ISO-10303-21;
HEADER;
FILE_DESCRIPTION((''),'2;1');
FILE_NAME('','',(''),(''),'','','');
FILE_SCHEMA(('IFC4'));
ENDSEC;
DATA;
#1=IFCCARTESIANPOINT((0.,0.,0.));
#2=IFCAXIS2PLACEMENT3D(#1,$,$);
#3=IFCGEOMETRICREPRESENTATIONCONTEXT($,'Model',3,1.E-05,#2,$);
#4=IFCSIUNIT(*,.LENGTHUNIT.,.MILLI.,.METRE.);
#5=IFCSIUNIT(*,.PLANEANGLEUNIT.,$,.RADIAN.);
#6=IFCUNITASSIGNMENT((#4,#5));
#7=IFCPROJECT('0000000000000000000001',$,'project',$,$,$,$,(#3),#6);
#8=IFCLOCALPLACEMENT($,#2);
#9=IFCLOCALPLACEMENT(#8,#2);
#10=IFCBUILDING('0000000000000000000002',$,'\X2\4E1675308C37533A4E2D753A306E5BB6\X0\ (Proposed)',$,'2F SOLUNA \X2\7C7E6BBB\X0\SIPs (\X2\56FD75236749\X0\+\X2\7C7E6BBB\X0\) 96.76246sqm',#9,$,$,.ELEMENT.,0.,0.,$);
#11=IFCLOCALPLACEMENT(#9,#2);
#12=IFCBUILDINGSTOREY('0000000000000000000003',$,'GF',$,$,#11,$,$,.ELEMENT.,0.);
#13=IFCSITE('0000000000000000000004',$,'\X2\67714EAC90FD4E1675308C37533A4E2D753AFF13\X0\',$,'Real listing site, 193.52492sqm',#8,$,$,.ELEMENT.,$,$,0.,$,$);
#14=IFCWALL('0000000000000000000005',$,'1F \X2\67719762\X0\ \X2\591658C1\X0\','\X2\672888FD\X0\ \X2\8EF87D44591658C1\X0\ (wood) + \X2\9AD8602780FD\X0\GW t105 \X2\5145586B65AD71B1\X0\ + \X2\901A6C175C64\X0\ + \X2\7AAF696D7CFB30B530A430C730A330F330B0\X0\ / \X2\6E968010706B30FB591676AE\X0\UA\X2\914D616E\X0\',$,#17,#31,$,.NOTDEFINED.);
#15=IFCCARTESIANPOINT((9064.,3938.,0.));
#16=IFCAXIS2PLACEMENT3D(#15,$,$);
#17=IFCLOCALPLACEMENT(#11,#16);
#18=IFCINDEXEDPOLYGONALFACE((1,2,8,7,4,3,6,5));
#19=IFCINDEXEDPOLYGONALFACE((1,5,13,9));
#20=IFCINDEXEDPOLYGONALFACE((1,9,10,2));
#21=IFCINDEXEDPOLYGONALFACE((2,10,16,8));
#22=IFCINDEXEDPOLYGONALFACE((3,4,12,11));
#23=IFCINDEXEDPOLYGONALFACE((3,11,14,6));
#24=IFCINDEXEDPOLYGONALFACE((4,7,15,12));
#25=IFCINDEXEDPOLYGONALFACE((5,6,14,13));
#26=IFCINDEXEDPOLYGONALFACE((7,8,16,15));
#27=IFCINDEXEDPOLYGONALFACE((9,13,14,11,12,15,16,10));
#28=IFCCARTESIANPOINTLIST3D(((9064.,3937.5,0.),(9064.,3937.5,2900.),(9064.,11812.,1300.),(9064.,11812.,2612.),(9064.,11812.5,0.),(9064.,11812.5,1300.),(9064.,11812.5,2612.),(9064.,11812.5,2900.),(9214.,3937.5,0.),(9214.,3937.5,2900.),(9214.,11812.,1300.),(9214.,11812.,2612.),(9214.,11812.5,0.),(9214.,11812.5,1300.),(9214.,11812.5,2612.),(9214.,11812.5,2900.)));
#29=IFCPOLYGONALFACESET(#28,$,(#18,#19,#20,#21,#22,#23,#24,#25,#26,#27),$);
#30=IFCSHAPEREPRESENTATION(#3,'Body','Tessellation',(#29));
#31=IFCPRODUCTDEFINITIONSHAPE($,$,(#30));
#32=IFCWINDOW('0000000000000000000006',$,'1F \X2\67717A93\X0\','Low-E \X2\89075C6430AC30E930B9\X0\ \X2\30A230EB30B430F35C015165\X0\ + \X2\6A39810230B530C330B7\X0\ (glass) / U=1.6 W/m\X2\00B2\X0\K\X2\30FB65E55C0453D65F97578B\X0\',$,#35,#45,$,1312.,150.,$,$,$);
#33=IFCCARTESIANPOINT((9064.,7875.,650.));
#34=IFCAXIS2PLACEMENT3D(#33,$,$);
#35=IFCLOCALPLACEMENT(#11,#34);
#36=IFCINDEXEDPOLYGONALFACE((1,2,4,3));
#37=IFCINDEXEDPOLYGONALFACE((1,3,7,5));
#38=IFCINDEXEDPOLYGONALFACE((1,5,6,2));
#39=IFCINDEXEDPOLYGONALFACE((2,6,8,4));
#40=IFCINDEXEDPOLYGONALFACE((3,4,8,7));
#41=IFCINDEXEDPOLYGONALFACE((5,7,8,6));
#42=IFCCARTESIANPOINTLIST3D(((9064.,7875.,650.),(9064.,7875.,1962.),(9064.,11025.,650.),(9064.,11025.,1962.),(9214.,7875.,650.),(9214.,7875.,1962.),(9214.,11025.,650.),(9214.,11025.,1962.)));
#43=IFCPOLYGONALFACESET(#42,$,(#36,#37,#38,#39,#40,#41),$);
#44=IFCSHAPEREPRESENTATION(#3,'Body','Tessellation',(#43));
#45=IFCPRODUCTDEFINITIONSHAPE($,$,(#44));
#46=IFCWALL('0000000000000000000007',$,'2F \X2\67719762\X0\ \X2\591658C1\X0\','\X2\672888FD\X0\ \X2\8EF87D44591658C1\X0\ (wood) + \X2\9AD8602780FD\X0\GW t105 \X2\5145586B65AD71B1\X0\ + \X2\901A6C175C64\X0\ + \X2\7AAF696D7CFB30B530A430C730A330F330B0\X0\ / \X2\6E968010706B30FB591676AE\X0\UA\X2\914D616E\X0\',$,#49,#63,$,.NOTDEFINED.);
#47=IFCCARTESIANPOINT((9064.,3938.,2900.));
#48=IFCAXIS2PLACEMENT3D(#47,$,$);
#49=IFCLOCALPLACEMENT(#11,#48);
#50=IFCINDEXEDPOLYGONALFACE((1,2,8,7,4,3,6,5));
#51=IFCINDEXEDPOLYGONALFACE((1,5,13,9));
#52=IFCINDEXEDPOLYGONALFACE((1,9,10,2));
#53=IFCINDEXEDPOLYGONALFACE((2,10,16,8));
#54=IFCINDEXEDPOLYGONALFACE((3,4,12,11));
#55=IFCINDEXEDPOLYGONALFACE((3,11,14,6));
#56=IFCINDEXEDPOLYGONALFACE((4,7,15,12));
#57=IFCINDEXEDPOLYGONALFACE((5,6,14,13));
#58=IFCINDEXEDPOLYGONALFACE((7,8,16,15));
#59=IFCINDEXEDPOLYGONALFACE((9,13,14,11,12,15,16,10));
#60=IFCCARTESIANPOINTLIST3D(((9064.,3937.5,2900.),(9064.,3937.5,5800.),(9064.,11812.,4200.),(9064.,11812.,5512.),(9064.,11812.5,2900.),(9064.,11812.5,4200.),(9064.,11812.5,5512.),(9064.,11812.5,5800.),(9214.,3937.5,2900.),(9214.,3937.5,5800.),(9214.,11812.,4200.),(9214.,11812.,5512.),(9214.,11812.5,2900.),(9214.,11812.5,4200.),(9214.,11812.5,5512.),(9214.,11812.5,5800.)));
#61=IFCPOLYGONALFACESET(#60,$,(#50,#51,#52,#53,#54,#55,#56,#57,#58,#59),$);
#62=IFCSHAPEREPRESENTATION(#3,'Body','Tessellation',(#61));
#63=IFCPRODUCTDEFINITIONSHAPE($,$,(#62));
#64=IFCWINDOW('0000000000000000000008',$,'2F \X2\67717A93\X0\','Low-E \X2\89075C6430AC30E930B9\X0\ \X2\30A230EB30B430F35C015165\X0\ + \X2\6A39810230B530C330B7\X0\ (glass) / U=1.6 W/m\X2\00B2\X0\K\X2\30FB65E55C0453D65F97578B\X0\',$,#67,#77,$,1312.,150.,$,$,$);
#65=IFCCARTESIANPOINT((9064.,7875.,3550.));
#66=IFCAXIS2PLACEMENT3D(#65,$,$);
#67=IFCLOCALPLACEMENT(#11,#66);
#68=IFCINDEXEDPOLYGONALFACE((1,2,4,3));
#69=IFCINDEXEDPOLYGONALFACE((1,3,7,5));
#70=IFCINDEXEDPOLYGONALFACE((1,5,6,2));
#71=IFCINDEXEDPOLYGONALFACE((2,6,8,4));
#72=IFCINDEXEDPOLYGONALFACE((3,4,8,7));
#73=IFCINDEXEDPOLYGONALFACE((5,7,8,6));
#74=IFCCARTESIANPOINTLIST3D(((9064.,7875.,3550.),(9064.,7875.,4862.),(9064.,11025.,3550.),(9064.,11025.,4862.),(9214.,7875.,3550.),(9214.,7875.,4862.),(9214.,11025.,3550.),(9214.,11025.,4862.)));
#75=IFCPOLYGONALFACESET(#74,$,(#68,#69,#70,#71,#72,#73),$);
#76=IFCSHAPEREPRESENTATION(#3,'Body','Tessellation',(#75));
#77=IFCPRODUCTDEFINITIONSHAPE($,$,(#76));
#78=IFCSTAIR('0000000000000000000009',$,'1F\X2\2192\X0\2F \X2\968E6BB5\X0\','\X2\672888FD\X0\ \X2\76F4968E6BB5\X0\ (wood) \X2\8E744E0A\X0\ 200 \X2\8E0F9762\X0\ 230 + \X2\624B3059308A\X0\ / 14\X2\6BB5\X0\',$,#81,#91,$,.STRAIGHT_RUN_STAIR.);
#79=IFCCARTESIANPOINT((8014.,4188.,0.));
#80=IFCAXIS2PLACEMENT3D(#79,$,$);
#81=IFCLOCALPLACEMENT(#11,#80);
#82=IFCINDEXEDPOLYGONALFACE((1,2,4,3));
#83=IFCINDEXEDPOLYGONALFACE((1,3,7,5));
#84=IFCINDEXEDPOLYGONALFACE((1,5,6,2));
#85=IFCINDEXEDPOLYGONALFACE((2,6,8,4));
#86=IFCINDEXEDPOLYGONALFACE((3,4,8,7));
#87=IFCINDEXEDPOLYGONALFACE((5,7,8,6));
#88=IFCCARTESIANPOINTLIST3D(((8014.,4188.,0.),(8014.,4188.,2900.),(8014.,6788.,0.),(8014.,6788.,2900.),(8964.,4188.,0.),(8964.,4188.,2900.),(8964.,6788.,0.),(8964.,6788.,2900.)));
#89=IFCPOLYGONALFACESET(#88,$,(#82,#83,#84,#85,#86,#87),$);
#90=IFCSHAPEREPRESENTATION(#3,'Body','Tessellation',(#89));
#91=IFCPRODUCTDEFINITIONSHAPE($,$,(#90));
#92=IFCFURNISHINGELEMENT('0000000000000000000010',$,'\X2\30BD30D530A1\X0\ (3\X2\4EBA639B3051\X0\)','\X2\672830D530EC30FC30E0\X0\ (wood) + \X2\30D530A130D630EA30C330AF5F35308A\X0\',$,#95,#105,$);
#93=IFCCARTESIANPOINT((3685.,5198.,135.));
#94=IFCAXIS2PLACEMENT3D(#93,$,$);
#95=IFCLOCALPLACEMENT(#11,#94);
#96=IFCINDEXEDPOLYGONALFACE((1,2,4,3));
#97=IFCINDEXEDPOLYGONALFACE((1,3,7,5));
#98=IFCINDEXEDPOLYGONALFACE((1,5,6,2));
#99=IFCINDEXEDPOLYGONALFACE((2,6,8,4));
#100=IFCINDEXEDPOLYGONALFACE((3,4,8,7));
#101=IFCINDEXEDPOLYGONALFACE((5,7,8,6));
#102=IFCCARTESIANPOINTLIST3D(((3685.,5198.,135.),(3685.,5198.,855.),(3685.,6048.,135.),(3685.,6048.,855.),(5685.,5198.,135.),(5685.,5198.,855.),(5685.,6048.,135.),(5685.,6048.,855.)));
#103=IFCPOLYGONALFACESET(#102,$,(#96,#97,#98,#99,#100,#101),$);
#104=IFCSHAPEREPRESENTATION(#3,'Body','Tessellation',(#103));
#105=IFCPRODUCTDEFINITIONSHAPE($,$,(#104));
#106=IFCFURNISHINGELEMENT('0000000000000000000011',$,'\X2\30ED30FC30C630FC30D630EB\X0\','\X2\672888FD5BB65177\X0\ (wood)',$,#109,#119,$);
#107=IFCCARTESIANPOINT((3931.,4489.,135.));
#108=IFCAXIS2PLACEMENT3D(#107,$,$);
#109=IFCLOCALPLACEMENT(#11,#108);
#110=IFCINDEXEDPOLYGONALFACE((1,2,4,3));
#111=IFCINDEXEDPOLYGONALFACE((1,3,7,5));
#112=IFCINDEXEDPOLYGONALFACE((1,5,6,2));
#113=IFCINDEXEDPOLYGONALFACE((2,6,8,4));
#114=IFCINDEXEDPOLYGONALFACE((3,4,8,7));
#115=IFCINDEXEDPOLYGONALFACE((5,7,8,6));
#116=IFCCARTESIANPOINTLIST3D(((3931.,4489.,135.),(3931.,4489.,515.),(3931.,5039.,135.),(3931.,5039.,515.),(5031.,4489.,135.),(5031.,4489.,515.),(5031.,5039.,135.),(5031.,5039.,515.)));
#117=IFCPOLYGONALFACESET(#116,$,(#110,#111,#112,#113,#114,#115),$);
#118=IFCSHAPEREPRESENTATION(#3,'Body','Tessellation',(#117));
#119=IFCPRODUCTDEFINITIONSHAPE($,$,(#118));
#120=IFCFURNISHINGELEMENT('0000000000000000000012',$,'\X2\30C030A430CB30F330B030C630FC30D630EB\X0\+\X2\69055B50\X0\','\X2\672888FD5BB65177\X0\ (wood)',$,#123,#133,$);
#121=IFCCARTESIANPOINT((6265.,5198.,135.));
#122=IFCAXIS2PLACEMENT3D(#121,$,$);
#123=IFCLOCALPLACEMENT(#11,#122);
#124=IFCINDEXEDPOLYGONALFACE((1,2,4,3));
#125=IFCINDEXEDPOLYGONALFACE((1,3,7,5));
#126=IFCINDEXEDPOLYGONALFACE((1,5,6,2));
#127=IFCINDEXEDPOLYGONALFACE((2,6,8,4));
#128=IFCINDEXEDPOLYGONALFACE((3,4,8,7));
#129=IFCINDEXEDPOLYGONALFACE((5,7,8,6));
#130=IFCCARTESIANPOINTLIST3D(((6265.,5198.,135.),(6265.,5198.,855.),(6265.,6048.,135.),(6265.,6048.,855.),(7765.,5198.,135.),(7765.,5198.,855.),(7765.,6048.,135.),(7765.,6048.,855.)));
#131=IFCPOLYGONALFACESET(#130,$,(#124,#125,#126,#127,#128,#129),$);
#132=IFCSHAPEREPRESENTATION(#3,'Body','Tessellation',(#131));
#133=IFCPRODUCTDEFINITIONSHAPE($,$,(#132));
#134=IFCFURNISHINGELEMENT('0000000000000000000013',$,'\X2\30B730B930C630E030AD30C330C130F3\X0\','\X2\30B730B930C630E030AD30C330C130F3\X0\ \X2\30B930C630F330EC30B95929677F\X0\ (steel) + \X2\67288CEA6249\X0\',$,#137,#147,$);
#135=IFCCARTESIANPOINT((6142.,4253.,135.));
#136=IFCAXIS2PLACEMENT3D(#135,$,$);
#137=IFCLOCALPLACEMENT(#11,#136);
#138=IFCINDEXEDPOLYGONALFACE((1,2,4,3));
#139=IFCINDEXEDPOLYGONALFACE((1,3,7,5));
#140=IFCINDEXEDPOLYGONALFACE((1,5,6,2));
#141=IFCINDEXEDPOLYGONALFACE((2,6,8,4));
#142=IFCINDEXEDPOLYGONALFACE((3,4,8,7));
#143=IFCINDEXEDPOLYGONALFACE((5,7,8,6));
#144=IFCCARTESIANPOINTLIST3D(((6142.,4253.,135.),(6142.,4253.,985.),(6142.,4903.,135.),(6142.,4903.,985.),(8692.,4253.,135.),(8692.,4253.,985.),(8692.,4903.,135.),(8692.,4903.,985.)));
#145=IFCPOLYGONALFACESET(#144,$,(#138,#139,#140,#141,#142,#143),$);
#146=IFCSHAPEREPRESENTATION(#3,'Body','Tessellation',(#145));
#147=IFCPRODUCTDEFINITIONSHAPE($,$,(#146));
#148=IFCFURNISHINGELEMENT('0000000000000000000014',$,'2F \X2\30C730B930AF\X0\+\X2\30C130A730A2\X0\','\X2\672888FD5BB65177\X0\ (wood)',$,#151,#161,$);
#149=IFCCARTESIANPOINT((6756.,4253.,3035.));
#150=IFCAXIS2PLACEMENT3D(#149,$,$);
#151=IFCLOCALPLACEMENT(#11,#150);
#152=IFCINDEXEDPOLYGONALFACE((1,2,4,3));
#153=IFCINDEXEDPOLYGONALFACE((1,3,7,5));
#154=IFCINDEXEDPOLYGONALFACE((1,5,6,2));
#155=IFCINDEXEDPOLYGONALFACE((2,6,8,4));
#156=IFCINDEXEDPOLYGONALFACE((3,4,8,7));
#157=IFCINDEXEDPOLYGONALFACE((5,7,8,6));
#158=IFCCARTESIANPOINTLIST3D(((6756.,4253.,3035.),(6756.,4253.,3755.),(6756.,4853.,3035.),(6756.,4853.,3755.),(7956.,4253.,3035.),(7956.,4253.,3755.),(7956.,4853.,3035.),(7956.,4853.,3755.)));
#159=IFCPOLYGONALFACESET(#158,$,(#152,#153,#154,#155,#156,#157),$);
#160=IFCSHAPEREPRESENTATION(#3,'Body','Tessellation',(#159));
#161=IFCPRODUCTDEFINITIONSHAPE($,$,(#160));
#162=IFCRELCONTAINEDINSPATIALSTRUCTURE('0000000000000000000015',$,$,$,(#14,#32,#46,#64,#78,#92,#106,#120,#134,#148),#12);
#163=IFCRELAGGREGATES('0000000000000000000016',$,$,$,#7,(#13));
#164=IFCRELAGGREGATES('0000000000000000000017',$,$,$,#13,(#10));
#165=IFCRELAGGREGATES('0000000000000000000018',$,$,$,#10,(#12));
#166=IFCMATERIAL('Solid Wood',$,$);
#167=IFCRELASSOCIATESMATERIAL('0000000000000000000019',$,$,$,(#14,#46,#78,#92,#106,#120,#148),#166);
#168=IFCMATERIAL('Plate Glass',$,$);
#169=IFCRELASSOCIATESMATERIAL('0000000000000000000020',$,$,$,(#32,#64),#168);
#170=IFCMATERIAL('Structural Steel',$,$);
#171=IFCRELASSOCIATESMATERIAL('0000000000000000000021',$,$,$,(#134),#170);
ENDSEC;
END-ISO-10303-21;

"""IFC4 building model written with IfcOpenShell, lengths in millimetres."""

from ifc_helpers import new_model, si_unit, frame, frame_2d, origin, place, context, project, spatial, rectangle, extrude, material, element, fill, save


model = new_model("IFC4")

# Units and contexts
model_context = context("Model", 3, precision=1e-05, world=origin())
ifc_project = project(units=[si_unit("LENGTHUNIT", "METRE", prefix="MILLI"), si_unit("PLANEANGLEUNIT", "RADIAN")], contexts=[model_context])

# Site, building, storey
site_placement = place(None, origin())
site = spatial("IfcSite", under=ifc_project, at=site_placement, Name="東京都世田谷区中町３", ObjectType="Real listing site, 193.52492sqm", CompositionType="ELEMENT", RefElevation=0.0)
building_placement = place(site_placement, origin())
building = spatial("IfcBuilding", under=site, at=building_placement, Name="世田谷区中町の家 (Proposed)", ObjectType="2F SOLUNA 籾殻SIPs (国産杉+籾殻) 96.76246sqm", CompositionType="ELEMENT", ElevationOfRefHeight=0.0, ElevationOfTerrain=0.0)
storey_placement = place(building_placement, origin())
storey = spatial("IfcBuildingStorey", under=building, at=storey_placement, Name="GF", CompositionType="ELEMENT", Elevation=0.0)

# Wall, opening, window
ifc_material_1 = material(Name="Solid Wood")
wall_1_placement = place(storey_placement, frame((9064.0, 3938.0, 0.0)))
wall_1 = element("IfcWall", 1, at=wall_1_placement, inside=storey, material=ifc_material_1, Name="1F 東面 外壁", Description="木製 軸組外壁 (wood) + 高性能GW t105 充填断熱 + 通気層 + 窯業系サイディング / 準耐火・外皮UA配慮", PredefinedType="NOTDEFINED", context=model_context, shape_type="SweptSolid", body=[
    extrude(rectangle(XDim=150.0, YDim=7875.0, at=frame_2d((75.0, 3937.0))), frame((9064.0, 3938.0, 0.0)), (0.0, 0.0, 1.0), 2900.0),
])
opening_1_placement = place(storey_placement, frame((9064.0, 7875.0, 650.0)))
opening_1 = element("IfcOpeningElement", 2, at=opening_1_placement, cuts=wall_1, PredefinedType="NOTDEFINED", context=model_context, shape_type="SweptSolid", body=[
    extrude(rectangle(XDim=150.0, YDim=3150.0, at=frame_2d((75.0, 1575.0))), frame((9064.0, 7875.0, 650.0)), (0.0, 0.0, 1.0), 1312.0),
])
ifc_material_2 = material(Name="Plate Glass")
window_1_placement = place(storey_placement, frame((9064.0, 7875.0, 650.0)))
window_1 = element("IfcWindow", 3, at=window_1_placement, inside=storey, material=ifc_material_2, Name="1F 東窓", Description="Low-E 複層ガラス アルゴン封入 + 樹脂サッシ (glass) / U=1.6 W/m²K・日射取得型", OverallHeight=1312.0, OverallWidth=150.0, context=model_context, shape_type="SweptSolid", body=[
    extrude(rectangle(XDim=150.0, YDim=3150.0, at=frame_2d((75.0, 1575.0))), frame((9064.0, 7875.0, 650.0)), (0.0, 0.0, 1.0), 1312.0),
])
fill(opening_1, window_1)

# Wall, opening, window
wall_2_placement = place(storey_placement, frame((9064.0, 3938.0, 2900.0)))
wall_2 = element("IfcWall", 4, at=wall_2_placement, inside=storey, material=ifc_material_1, Name="2F 東面 外壁", Description="木製 軸組外壁 (wood) + 高性能GW t105 充填断熱 + 通気層 + 窯業系サイディング / 準耐火・外皮UA配慮", PredefinedType="NOTDEFINED", context=model_context, shape_type="SweptSolid", body=[
    extrude(rectangle(XDim=150.0, YDim=7875.0, at=frame_2d((75.0, 3937.0))), frame((9064.0, 3938.0, 2900.0)), (0.0, 0.0, 1.0), 2900.0),
])
opening_2_placement = place(storey_placement, frame((9064.0, 7875.0, 3550.0)))
opening_2 = element("IfcOpeningElement", 5, at=opening_2_placement, cuts=wall_2, PredefinedType="NOTDEFINED", context=model_context, shape_type="SweptSolid", body=[
    extrude(rectangle(XDim=150.0, YDim=3150.0, at=frame_2d((75.0, 1575.0))), frame((9064.0, 7875.0, 3550.0)), (0.0, 0.0, 1.0), 1312.0),
])
window_2_placement = place(storey_placement, frame((9064.0, 7875.0, 3550.0)))
window_2 = element("IfcWindow", 6, at=window_2_placement, inside=storey, material=ifc_material_2, Name="2F 東窓", Description="Low-E 複層ガラス アルゴン封入 + 樹脂サッシ (glass) / U=1.6 W/m²K・日射取得型", OverallHeight=1312.0, OverallWidth=150.0, context=model_context, shape_type="SweptSolid", body=[
    extrude(rectangle(XDim=150.0, YDim=3150.0, at=frame_2d((75.0, 1575.0))), frame((9064.0, 7875.0, 3550.0)), (0.0, 0.0, 1.0), 1312.0),
])
fill(opening_2, window_2)

# Stair
stair_placement = place(storey_placement, frame((8014.0, 4188.0, 0.0)))
element("IfcStair", 7, at=stair_placement, inside=storey, material=ifc_material_1, Name="1F→2F 階段", Description="木製 直階段 (wood) 蹴上 200 踏面 230 + 手すり / 14段", PredefinedType="STRAIGHT_RUN_STAIR", context=model_context, shape_type="SweptSolid", body=[
    extrude(rectangle(XDim=950.0, YDim=2600.0, at=frame_2d((475.0, 1300.0))), frame((8014.0, 4188.0, 0.0)), (0.0, 0.0, 1.0), 2900.0),
])

# Furnishing elements
furnishing_1_placement = place(storey_placement, frame((3685.0, 5198.0, 135.0)))
element("IfcFurnishingElement", 8, at=furnishing_1_placement, inside=storey, material=ifc_material_1, Name="ソファ (3人掛け)", Description="木フレーム (wood) + ファブリック張り", context=model_context, shape_type="SweptSolid", body=[
    extrude(rectangle(XDim=2000.0, YDim=850.0, at=frame_2d((1000.0, 425.0))), frame((3685.0, 5198.0, 135.0)), (0.0, 0.0, 1.0), 720.0),
])
furnishing_2_placement = place(storey_placement, frame((3931.0, 4489.0, 135.0)))
element("IfcFurnishingElement", 9, at=furnishing_2_placement, inside=storey, material=ifc_material_1, Name="ローテーブル", Description="木製家具 (wood)", context=model_context, shape_type="SweptSolid", body=[
    extrude(rectangle(XDim=1100.0, YDim=550.0, at=frame_2d((550.0, 275.0))), frame((3931.0, 4489.0, 135.0)), (0.0, 0.0, 1.0), 380.0),
])
furnishing_3_placement = place(storey_placement, frame((6265.0, 5198.0, 135.0)))
element("IfcFurnishingElement", 10, at=furnishing_3_placement, inside=storey, material=ifc_material_1, Name="ダイニングテーブル+椅子", Description="木製家具 (wood)", context=model_context, shape_type="SweptSolid", body=[
    extrude(rectangle(XDim=1500.0, YDim=850.0, at=frame_2d((750.0, 425.0))), frame((6265.0, 5198.0, 135.0)), (0.0, 0.0, 1.0), 720.0),
])
ifc_material_3 = material(Name="Structural Steel")
furnishing_4_placement = place(storey_placement, frame((6142.0, 4253.0, 135.0)))
element("IfcFurnishingElement", 11, at=furnishing_4_placement, inside=storey, material=ifc_material_3, Name="システムキッチン", Description="システムキッチン ステンレス天板 (steel) + 木質扉", context=model_context, shape_type="SweptSolid", body=[
    extrude(rectangle(XDim=2550.0, YDim=650.0, at=frame_2d((1275.0, 325.0))), frame((6142.0, 4253.0, 135.0)), (0.0, 0.0, 1.0), 850.0),
])
furnishing_5_placement = place(storey_placement, frame((6756.0, 4253.0, 3035.0)))
element("IfcFurnishingElement", 12, at=furnishing_5_placement, inside=storey, material=ifc_material_1, Name="2F デスク+チェア", Description="木製家具 (wood)", context=model_context, shape_type="SweptSolid", body=[
    extrude(rectangle(XDim=1200.0, YDim=600.0, at=frame_2d((600.0, 300.0))), frame((6756.0, 4253.0, 3035.0)), (0.0, 0.0, 1.0), 720.0),
])

save(model, "model.ifc")
